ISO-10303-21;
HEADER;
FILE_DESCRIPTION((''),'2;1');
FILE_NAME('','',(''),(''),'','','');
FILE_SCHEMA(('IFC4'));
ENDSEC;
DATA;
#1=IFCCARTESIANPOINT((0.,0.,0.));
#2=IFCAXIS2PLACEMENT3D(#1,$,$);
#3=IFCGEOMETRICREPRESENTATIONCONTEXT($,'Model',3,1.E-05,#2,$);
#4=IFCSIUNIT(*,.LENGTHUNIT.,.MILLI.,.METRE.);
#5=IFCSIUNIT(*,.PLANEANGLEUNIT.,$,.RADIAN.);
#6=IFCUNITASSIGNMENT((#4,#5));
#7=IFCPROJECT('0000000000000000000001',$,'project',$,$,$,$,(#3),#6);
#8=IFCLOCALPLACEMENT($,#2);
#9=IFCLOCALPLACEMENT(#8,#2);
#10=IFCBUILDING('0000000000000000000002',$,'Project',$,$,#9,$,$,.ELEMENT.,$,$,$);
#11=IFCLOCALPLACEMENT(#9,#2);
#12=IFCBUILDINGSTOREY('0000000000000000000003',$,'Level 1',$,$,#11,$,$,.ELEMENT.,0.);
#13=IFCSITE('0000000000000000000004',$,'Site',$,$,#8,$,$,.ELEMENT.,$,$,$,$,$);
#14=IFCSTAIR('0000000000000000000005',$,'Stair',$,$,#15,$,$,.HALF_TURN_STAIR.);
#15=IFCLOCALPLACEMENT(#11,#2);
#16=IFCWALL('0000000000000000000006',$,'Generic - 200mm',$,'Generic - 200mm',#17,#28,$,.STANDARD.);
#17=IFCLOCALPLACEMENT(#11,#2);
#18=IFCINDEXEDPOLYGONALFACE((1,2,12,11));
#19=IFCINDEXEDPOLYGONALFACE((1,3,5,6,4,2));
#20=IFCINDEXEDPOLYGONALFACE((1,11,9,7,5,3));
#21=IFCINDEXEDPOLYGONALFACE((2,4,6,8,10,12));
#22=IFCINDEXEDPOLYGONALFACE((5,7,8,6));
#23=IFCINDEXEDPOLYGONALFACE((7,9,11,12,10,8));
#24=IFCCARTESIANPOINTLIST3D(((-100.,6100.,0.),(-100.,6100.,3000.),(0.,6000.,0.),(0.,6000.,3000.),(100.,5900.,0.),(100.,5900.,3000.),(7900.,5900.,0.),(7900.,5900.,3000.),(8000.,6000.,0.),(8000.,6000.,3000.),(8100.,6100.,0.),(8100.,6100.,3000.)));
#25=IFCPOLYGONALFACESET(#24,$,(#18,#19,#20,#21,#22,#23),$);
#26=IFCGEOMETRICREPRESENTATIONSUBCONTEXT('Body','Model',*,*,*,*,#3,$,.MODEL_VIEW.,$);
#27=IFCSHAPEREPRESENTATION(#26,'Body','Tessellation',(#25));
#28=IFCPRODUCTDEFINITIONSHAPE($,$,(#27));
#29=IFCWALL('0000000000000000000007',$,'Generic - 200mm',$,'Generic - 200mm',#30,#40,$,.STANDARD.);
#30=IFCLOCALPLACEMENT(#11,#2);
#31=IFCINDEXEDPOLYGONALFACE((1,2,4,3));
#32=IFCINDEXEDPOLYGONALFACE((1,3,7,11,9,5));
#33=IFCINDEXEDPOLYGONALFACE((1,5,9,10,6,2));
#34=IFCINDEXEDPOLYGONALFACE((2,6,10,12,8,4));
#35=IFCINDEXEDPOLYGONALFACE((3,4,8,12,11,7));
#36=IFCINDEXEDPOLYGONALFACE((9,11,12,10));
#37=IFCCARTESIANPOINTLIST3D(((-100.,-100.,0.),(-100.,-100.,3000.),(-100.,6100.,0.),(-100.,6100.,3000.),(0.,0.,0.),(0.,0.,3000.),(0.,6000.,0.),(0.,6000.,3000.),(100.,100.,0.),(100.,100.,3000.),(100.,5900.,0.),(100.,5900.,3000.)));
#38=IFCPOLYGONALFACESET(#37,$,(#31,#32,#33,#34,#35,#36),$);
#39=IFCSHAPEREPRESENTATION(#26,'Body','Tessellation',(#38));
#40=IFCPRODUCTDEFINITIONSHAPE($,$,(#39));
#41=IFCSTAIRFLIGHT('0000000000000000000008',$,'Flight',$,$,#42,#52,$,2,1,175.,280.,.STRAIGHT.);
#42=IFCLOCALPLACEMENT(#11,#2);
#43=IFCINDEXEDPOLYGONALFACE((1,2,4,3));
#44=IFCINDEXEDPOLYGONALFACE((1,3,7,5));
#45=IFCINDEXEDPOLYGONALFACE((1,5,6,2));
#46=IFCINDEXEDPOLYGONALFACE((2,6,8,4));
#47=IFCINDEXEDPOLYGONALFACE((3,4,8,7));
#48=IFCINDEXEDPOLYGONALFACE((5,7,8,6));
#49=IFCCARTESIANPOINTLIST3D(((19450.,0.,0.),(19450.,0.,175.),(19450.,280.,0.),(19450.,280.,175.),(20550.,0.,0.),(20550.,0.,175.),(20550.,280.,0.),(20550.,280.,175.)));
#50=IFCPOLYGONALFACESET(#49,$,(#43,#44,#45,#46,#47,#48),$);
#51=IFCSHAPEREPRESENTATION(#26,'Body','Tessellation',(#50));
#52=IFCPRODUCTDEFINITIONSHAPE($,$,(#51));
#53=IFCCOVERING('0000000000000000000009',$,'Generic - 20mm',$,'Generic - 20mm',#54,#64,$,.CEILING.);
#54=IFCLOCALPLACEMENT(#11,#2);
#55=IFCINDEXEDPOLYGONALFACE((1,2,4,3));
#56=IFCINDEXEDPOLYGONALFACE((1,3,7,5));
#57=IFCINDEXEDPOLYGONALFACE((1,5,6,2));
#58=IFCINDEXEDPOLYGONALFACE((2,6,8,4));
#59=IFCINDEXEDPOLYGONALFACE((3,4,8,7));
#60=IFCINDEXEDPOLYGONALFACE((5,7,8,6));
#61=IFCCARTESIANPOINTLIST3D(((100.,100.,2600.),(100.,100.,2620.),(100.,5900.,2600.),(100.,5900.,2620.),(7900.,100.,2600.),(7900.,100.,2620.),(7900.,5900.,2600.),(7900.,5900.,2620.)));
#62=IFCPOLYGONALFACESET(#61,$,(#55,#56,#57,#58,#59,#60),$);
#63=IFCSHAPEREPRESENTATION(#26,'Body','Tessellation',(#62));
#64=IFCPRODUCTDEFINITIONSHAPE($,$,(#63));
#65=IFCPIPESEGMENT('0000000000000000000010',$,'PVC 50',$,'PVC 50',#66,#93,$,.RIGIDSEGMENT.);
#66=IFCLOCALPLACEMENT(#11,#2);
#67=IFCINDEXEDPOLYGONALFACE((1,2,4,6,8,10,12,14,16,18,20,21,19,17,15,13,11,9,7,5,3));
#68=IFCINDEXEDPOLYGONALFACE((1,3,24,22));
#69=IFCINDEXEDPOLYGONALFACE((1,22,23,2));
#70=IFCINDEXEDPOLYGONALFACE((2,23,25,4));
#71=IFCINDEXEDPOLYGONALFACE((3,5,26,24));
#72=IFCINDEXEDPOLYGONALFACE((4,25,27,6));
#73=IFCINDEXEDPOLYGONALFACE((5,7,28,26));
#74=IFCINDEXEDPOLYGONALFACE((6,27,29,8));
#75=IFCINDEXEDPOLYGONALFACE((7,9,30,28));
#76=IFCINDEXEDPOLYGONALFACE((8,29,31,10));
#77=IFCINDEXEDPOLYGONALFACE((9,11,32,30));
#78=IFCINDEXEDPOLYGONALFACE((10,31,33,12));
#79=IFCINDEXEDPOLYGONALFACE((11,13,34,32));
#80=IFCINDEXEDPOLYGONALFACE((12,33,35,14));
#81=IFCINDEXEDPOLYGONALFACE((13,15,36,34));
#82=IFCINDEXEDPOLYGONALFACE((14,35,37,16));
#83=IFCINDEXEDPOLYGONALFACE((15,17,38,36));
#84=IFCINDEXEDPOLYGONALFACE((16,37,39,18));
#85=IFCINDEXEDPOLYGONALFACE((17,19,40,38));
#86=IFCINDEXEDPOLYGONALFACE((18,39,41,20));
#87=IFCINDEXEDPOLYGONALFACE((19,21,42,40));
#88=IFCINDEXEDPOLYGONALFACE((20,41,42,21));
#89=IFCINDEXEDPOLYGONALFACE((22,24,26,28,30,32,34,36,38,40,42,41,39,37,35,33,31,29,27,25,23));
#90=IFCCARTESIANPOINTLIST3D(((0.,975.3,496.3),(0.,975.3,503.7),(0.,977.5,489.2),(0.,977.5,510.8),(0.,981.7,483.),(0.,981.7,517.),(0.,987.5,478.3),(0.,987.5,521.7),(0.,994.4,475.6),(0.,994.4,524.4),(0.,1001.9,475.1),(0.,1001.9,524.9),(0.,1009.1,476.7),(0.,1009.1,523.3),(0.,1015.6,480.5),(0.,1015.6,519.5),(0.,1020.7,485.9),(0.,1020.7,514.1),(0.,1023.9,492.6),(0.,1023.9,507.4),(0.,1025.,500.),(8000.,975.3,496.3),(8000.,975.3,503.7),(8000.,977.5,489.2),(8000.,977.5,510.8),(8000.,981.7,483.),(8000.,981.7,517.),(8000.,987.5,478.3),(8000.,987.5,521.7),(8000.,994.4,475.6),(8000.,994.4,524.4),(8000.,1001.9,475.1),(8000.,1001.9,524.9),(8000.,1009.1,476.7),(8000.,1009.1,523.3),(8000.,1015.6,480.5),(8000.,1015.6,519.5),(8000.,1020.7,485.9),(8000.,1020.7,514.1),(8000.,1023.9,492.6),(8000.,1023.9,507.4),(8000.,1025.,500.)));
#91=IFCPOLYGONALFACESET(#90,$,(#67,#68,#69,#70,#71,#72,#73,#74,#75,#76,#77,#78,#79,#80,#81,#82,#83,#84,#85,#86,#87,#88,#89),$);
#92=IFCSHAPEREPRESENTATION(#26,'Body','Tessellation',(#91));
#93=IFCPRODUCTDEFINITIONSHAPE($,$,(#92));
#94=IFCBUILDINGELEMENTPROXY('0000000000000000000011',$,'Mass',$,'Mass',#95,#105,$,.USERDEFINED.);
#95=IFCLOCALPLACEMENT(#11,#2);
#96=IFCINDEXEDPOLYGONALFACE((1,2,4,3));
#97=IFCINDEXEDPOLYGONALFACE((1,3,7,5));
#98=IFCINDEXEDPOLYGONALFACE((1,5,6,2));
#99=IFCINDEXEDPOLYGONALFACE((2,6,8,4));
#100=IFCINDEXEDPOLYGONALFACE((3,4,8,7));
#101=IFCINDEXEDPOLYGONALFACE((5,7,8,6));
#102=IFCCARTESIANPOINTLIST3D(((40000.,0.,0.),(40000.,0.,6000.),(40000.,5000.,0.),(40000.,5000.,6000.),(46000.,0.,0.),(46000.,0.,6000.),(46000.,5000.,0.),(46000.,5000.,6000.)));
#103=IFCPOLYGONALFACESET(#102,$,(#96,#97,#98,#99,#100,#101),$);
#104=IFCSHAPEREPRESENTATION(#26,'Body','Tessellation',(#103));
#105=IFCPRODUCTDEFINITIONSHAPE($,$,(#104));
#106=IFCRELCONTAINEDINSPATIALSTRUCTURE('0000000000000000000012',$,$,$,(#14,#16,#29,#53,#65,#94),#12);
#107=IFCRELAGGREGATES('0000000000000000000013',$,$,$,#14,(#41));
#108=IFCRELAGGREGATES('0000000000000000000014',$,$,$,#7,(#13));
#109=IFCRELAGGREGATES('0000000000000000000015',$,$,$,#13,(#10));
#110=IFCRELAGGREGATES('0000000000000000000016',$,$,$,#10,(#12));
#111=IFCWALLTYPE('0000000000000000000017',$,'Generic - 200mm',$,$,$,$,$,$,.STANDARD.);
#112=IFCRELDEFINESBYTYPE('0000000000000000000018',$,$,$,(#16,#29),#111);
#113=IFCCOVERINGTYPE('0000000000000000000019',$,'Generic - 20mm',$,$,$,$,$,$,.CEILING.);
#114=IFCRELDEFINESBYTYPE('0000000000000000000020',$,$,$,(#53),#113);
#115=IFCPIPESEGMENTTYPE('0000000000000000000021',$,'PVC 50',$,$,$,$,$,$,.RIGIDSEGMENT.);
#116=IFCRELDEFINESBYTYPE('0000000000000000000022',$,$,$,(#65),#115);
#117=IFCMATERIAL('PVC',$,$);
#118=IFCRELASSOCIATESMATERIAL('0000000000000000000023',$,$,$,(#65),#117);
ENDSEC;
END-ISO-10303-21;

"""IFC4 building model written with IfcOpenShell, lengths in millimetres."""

from ifc_helpers import new_model, si_unit, frame, frame_2d, origin, origin_2d, place, context, subcontext, project, spatial, polyline, rectangle, circle, outline, extrude, material, type_object, element, aggregate, save


model = new_model("IFC4")

# Units and contexts
model_context = context("Model", 3, precision=1e-05, world=origin())
body_context = subcontext(model_context, "Body", "Model", "MODEL_VIEW")
ifc_project = project(units=[si_unit("LENGTHUNIT", "METRE", prefix="MILLI"), si_unit("PLANEANGLEUNIT", "RADIAN")], contexts=[model_context])

# Site, building, storey
site_placement = place(None, origin())
site = spatial("IfcSite", under=ifc_project, at=site_placement, Name="Site", CompositionType="ELEMENT")
building_placement = place(site_placement, origin())
building = spatial("IfcBuilding", under=site, at=building_placement, Name="Project", CompositionType="ELEMENT")
storey_placement = place(building_placement, origin())
storey = spatial("IfcBuildingStorey", under=building, at=storey_placement, Name="Level 1", CompositionType="ELEMENT", Elevation=0.0)

# Stair
stair_placement = place(storey_placement, origin())
stair = element("IfcStair", 1, at=stair_placement, inside=storey, Name="Stair", PredefinedType="HALF_TURN_STAIR")

# Shared definitions
wall_type = type_object("IfcWallType", Name="Generic - 200mm", PredefinedType="STANDARD")

# Walls
wall_1_placement = place(storey_placement, frame((8000.0, 6000.0, 0.0), z_axis=(0.0, 0.0, 1.0), x_axis=(-1.0, 0.0, 0.0)))
element("IfcWall", 2, at=wall_1_placement, inside=storey, type_object=wall_type, Name="Generic - 200mm", ObjectType="Generic - 200mm", PredefinedType="STANDARD", context=body_context, shape_type="SweptSolid", body=[
    extrude(outline(polyline([(-100.0, -100.0), (0.0, 0.0), (100.0, 100.0), (7900.0, 100.0), (8000.0, 0.0), (8100.0, -100.0), (-100.0, -100.0)])), origin(), (0.0, 0.0, 1.0), 3000.0),
])
wall_2_placement = place(storey_placement, frame((0.0, 6000.0, 0.0), z_axis=(0.0, 0.0, 1.0), x_axis=(0.0, -1.0, 0.0)))
element("IfcWall", 3, at=wall_2_placement, inside=storey, type_object=wall_type, Name="Generic - 200mm", ObjectType="Generic - 200mm", PredefinedType="STANDARD", context=body_context, shape_type="SweptSolid", body=[
    extrude(outline(polyline([(-100.0, -100.0), (0.0, 0.0), (100.0, 100.0), (5900.0, 100.0), (6000.0, 0.0), (6100.0, -100.0), (-100.0, -100.0)])), origin(), (0.0, 0.0, 1.0), 3000.0),
])

# Stair flight
stair_flight_1_placement = place(stair_placement, frame((20000.0, 0.0, 0.0), z_axis=(0.0, 0.0, 1.0), x_axis=(0.0, 1.0, 0.0)))
stair_flight_1 = element("IfcStairFlight", 4, at=stair_flight_1_placement, Name="Flight", NumberOfRisers=2, NumberOfTreads=1, PredefinedType="STRAIGHT", RiserHeight=175.0, TreadLength=280.0, context=body_context, shape_type="SweptSolid", body=[
    extrude(rectangle(XDim=280.0, YDim=1100.0, at=frame_2d((140.0, 0.0))), origin(), (0.0, 0.0, 1.0), 175.0),
])
aggregate(stair, [stair_flight_1])

# Covering
covering_type = type_object("IfcCoveringType", Name="Generic - 20mm", PredefinedType="CEILING")
covering_placement = place(storey_placement, origin())
element("IfcCovering", 5, at=covering_placement, inside=storey, type_object=covering_type, Name="Generic - 20mm", ObjectType="Generic - 20mm", PredefinedType="CEILING", context=body_context, shape_type="SweptSolid", body=[
    extrude(outline(polyline([(100.0, 100.0), (7900.0, 100.0), (7900.0, 5900.0), (100.0, 5900.0), (100.0, 100.0)])), frame((0.0, 0.0, 2600.0)), (0.0, 0.0, 1.0), 20.0),
])

# Pipe segment
ifc_material_1 = material(Name="PVC")
pipe_segment_type = type_object("IfcPipeSegmentType", Name="PVC 50", PredefinedType="RIGIDSEGMENT")
pipe_segment_placement = place(storey_placement, frame((0.0, 1000.0, 500.0)))
element("IfcPipeSegment", 6, at=pipe_segment_placement, inside=storey, type_object=pipe_segment_type, material=ifc_material_1, Name="PVC 50", ObjectType="PVC 50", PredefinedType="RIGIDSEGMENT", context=body_context, shape_type="SweptSolid", body=[
    extrude(circle(Radius=25.0, at=origin_2d()), frame((0.0, 0.0, 0.0), z_axis=(1.0, 0.0, 0.0), x_axis=(0.0, 1.0, 0.0)), (0.0, 0.0, 1.0), 8000.0),
])

# Building element proxy
proxy_placement = place(storey_placement, origin())
element("IfcBuildingElementProxy", 7, at=proxy_placement, inside=storey, Name="Mass", ObjectType="Mass", PredefinedType="USERDEFINED", context=body_context, shape_type="SweptSolid", body=[
    extrude(outline(polyline([(40000.0, 0.0), (46000.0, 0.0), (46000.0, 5000.0), (40000.0, 5000.0), (40000.0, 0.0)])), origin(), (0.0, 0.0, 1.0), 6000.0),
])

save(model, "model.ifc")
